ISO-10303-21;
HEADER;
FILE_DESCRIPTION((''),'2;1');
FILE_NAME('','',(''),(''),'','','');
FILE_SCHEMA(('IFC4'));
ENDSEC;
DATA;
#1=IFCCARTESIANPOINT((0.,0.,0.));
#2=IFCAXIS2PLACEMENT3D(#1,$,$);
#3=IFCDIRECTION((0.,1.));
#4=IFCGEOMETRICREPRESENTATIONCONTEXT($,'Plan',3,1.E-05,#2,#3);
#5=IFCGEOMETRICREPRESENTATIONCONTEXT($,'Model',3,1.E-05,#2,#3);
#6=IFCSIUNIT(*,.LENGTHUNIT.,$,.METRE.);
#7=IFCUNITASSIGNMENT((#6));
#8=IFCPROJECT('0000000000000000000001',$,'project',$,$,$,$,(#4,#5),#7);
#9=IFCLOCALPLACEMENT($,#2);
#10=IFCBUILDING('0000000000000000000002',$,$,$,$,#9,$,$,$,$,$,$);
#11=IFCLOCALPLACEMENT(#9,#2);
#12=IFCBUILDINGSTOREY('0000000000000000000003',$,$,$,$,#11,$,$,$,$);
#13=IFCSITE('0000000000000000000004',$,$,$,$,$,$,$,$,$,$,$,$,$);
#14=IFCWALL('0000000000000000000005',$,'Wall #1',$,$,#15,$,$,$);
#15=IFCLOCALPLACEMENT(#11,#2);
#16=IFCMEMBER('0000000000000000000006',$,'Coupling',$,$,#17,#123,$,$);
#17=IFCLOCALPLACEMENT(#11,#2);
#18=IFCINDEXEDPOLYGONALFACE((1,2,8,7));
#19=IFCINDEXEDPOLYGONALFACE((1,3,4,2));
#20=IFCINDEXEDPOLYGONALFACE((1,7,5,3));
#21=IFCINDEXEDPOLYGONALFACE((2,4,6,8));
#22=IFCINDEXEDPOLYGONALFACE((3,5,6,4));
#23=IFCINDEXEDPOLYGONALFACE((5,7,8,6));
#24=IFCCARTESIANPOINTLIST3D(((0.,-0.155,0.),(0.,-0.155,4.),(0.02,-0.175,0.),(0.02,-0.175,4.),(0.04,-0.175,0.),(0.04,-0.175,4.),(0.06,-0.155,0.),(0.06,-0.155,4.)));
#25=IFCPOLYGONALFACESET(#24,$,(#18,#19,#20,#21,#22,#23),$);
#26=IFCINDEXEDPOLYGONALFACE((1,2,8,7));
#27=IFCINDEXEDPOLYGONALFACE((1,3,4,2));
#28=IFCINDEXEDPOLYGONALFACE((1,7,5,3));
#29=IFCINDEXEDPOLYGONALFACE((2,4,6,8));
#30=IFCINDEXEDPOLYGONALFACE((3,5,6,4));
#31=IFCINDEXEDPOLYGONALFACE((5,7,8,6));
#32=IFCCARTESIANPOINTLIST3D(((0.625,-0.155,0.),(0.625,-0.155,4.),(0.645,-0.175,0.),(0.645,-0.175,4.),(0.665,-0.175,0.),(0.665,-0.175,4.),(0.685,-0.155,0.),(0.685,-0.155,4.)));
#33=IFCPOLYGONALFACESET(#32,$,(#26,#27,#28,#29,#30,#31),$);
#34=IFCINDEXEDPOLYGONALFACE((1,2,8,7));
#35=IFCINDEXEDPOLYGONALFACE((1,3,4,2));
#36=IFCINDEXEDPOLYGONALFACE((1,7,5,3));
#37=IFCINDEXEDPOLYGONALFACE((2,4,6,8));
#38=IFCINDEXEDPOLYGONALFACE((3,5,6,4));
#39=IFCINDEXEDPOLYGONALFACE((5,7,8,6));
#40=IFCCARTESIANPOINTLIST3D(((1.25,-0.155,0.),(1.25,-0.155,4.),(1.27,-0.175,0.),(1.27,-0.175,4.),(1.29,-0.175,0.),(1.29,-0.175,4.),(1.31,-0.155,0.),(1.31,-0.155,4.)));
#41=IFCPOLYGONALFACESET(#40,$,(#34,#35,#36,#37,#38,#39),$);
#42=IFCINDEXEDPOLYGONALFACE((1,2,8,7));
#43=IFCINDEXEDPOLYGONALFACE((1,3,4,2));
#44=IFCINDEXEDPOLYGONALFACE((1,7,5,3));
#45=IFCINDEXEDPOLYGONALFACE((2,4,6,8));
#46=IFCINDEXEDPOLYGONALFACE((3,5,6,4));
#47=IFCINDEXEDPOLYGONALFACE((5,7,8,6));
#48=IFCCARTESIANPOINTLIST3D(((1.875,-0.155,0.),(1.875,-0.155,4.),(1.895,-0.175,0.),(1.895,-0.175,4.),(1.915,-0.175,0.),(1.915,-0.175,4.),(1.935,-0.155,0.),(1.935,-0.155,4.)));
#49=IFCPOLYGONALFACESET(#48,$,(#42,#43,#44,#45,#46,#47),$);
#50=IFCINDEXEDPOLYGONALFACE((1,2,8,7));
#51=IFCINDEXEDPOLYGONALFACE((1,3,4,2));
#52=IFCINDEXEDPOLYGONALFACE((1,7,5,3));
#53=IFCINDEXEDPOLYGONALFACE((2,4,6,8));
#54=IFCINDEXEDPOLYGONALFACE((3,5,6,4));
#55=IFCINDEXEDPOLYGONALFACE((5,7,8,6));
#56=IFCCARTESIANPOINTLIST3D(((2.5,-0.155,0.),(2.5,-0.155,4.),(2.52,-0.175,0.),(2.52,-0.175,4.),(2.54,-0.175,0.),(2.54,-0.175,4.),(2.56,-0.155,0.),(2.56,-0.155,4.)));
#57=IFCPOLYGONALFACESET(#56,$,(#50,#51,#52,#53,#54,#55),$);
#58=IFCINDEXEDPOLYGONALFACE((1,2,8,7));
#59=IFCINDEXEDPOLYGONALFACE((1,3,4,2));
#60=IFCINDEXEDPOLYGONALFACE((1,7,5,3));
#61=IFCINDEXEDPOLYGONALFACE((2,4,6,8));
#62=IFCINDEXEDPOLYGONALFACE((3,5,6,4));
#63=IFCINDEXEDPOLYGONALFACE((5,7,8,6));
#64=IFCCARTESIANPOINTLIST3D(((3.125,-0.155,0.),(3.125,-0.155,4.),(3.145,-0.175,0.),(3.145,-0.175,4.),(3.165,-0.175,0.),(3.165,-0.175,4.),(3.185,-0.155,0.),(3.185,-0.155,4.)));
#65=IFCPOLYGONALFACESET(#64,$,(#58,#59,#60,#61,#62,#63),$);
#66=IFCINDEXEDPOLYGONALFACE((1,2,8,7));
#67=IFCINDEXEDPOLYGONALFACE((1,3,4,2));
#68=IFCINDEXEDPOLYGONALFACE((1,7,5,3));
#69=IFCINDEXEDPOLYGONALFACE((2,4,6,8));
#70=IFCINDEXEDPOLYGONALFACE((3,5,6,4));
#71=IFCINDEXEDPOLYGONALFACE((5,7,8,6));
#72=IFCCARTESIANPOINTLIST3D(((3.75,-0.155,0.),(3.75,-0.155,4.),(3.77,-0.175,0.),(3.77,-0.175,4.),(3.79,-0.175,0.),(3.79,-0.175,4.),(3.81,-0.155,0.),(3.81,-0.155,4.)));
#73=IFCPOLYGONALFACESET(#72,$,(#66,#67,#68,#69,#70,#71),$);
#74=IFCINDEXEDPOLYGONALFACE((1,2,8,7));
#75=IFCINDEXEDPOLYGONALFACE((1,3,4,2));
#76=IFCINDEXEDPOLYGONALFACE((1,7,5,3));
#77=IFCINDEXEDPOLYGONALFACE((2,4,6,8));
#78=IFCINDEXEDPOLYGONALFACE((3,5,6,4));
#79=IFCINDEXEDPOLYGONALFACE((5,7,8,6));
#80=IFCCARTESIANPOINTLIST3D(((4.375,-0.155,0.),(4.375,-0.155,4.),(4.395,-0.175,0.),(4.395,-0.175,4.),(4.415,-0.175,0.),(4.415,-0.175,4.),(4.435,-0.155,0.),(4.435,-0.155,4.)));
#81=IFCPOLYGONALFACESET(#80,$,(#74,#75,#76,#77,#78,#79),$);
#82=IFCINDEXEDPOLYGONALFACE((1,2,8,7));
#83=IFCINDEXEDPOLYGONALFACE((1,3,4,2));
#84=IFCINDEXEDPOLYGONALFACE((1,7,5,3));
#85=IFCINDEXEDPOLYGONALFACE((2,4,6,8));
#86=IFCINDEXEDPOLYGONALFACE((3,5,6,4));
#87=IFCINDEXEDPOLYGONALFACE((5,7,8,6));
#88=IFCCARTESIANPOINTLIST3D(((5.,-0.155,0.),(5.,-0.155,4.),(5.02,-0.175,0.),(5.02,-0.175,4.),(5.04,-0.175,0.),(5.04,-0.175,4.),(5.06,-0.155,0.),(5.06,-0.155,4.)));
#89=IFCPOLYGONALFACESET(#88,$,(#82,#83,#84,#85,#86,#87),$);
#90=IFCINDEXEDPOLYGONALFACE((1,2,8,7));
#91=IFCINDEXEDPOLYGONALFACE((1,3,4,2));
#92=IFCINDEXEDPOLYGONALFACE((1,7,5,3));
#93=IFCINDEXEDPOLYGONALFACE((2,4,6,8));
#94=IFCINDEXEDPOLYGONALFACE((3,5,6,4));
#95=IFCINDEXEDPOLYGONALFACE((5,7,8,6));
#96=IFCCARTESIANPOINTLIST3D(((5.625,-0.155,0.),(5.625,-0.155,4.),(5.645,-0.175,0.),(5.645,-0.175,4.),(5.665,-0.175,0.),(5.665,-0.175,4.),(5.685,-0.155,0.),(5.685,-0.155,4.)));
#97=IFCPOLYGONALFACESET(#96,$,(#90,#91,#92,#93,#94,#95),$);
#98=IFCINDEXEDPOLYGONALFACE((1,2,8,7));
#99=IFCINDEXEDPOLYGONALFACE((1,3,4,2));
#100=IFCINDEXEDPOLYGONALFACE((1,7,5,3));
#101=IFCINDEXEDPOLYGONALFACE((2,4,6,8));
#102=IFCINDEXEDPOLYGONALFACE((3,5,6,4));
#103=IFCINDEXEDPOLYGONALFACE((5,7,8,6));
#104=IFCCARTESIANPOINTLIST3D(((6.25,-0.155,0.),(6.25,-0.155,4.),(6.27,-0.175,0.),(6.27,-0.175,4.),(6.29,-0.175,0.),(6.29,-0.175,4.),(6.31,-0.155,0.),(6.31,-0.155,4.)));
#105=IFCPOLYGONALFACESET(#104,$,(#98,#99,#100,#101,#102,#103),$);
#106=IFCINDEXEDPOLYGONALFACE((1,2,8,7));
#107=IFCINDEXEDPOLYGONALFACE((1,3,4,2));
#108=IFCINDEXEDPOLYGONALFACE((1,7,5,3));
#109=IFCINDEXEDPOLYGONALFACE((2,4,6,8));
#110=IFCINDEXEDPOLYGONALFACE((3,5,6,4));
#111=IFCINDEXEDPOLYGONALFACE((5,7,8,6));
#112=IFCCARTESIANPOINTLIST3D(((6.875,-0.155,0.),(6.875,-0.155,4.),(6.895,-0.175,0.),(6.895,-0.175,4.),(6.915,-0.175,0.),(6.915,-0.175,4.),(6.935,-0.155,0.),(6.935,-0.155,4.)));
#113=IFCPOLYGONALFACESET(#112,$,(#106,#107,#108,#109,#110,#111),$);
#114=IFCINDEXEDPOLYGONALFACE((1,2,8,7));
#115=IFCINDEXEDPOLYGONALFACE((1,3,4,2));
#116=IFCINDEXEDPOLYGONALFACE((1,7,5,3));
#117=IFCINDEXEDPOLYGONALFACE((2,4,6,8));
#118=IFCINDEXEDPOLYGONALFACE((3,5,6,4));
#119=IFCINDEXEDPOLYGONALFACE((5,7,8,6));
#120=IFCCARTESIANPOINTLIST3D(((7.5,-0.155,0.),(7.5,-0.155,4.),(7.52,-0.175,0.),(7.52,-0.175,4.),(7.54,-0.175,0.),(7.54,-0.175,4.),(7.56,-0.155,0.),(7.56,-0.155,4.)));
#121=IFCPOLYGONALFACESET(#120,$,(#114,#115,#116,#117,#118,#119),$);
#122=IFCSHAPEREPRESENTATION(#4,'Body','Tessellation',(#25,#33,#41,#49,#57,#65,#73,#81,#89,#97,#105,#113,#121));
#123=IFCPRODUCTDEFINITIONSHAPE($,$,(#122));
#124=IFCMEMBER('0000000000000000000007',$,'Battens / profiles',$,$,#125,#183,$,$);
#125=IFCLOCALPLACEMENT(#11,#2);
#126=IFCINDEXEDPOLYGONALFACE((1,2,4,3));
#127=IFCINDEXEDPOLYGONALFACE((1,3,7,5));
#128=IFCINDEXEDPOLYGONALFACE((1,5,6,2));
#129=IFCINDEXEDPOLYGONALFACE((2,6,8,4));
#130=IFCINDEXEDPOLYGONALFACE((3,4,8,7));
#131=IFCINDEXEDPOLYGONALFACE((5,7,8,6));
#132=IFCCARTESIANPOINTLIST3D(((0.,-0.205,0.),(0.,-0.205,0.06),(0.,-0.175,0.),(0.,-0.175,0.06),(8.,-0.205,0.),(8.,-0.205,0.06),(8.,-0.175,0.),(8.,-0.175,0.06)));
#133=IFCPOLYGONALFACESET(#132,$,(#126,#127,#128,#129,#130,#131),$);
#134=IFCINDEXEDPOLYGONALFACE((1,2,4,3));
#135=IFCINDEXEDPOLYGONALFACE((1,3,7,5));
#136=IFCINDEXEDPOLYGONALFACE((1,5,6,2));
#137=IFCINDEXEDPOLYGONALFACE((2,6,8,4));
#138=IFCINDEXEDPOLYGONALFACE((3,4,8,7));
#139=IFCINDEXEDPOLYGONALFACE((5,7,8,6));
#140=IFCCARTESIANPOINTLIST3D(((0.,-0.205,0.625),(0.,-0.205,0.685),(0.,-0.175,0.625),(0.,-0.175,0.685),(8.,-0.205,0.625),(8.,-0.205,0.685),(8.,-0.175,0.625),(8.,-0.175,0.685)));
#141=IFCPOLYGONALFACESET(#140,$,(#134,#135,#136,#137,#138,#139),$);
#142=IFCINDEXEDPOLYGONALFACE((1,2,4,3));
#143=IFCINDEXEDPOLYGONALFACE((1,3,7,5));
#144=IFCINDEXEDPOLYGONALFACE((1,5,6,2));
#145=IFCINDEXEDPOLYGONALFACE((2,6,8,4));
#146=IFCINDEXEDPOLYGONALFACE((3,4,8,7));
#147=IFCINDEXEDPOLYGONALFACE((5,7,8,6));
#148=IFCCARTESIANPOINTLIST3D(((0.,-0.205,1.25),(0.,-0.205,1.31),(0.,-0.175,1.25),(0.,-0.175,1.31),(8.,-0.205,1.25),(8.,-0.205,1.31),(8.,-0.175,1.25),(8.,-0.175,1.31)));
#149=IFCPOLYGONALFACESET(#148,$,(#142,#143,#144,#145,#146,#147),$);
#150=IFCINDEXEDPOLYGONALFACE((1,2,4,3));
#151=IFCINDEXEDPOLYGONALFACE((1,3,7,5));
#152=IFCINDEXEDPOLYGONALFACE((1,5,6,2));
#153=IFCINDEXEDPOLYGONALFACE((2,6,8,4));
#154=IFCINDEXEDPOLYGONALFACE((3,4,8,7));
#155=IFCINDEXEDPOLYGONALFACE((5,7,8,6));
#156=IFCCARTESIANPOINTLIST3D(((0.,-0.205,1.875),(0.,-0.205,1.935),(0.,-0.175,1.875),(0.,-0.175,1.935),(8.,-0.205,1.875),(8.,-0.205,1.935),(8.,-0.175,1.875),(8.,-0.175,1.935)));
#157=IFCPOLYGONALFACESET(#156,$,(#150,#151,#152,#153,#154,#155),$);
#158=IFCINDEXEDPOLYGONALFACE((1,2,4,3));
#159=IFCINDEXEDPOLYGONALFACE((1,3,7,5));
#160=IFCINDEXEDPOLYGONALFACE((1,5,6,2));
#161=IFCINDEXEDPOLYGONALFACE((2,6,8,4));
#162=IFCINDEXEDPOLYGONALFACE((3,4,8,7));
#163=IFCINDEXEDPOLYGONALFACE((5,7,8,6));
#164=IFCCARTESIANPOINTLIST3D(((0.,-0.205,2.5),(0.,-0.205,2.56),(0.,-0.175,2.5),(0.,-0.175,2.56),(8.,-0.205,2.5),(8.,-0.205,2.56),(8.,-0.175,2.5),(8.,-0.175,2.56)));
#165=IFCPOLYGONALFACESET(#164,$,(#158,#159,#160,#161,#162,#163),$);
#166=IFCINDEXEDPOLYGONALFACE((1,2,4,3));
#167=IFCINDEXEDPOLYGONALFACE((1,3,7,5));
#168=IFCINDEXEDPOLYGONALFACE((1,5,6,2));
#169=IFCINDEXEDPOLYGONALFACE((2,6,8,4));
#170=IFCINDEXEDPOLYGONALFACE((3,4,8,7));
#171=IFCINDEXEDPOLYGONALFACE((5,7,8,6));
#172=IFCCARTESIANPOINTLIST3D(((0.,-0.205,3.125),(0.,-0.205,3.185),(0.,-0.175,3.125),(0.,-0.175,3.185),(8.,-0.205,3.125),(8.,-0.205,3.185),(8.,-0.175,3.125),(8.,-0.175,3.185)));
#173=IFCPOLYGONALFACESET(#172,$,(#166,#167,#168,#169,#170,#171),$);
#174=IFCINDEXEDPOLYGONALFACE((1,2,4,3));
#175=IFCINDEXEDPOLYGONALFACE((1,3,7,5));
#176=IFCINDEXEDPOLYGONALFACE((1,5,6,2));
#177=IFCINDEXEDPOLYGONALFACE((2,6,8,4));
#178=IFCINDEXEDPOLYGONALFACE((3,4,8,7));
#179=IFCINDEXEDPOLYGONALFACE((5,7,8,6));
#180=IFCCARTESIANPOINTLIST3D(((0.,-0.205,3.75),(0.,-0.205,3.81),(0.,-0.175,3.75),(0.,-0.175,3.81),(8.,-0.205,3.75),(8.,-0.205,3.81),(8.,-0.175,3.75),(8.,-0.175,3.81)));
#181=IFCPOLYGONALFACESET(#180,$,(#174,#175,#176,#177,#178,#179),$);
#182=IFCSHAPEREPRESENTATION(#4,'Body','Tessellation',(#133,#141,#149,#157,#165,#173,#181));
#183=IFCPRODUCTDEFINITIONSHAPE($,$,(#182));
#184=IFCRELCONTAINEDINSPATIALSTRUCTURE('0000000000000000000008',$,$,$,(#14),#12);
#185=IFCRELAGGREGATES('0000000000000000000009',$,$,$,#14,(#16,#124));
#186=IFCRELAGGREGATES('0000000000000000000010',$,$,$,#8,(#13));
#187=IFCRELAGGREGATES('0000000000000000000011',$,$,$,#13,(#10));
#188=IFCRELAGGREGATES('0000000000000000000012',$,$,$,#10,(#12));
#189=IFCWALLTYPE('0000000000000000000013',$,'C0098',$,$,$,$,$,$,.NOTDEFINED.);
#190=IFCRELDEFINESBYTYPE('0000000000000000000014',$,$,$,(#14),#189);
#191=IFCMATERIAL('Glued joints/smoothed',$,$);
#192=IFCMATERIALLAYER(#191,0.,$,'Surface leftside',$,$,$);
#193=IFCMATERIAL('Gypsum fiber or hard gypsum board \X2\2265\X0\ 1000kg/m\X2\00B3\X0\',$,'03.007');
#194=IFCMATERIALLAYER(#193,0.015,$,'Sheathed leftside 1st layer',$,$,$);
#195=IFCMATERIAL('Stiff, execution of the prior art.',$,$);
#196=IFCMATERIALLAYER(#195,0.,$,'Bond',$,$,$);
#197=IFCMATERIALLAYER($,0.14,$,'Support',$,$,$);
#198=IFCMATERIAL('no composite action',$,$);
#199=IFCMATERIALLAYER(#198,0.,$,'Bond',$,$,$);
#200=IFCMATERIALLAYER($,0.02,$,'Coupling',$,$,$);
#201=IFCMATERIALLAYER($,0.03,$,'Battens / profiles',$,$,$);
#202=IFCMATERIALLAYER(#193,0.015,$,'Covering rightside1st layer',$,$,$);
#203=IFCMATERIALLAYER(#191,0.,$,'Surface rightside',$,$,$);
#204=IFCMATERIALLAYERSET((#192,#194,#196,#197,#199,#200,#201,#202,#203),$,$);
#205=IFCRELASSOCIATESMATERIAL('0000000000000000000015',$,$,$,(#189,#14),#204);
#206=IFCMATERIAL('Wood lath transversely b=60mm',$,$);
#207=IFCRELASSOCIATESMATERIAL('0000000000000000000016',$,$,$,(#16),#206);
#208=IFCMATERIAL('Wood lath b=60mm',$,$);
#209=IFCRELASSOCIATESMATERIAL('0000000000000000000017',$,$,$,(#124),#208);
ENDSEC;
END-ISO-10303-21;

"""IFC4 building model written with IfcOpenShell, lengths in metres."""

from ifc_helpers import new_model, si_unit, direction, frame, frame_2d, origin, place, context, project, spatial, polyline, rectangle, outline, extrude, material, layer, layer_set, type_object, element, aggregate, save


model = new_model("IFC4")

# Units and contexts
plan_context = context("Plan", 3, precision=1e-05, world=origin(), true_north=direction((0.0, 1.0)))
model_context = context("Model", 3, precision=1e-05, world=origin(), true_north=direction((0.0, 1.0)))
ifc_project = project(units=[si_unit("LENGTHUNIT", "METRE")], contexts=[plan_context, model_context])

# Site, building, storey
site = spatial("IfcSite", under=ifc_project)
building_placement = place(None, origin())
building = spatial("IfcBuilding", under=site, at=building_placement)
storey_placement = place(building_placement, origin())
storey = spatial("IfcBuildingStorey", under=building, at=storey_placement)

# Wall, members
ifc_material_1 = material(Name="Glued joints/smoothed")
ifc_layer_1 = layer(ifc_material_1, 0.0, Name="Surface leftside")
ifc_material_2 = material(Name="Gypsum fiber or hard gypsum board ≥ 1000kg/m³", Category="03.007")
ifc_layer_2 = layer(ifc_material_2, 0.015, Name="Sheathed leftside 1st layer")
ifc_material_3 = material(Name="Stiff, execution of the prior art.")
ifc_layer_3 = layer(ifc_material_3, 0.0, Name="Bond")
ifc_layer_4 = layer(None, 0.14, Name="Support")
ifc_material_4 = material(Name="no composite action")
ifc_layer_5 = layer(ifc_material_4, 0.0, Name="Bond")
ifc_layer_6 = layer(None, 0.02, Name="Coupling")
ifc_layer_7 = layer(None, 0.03, Name="Battens / profiles")
ifc_layer_8 = layer(ifc_material_2, 0.015, Name="Covering rightside1st layer")
ifc_layer_9 = layer(ifc_material_1, 0.0, Name="Surface rightside")
ifc_layer_set = layer_set([ifc_layer_1, ifc_layer_2, ifc_layer_3, ifc_layer_4, ifc_layer_5, ifc_layer_6, ifc_layer_7, ifc_layer_8, ifc_layer_9])
wall_type = type_object("IfcWallType", Name="C0098", PredefinedType="NOTDEFINED", material=ifc_layer_set)
wall_placement = place(None, frame((0.0, 0.0, 0.0), z_axis=(0.0, -1.0, 0.0), x_axis=(1.0, 0.0, 0.0)))
wall = element("IfcWall", 1, at=wall_placement, inside=storey, type_object=wall_type, material=ifc_layer_set, Name="Wall #1")
ifc_material_5 = material(Name="Wood lath transversely b=60mm")
member_1_placement = place(wall_placement, origin())
member_1 = element("IfcMember", 2, at=member_1_placement, material=ifc_material_5, Name="Coupling", context=plan_context, shape_type="SweptSolid", body=[
    extrude(outline(polyline([(0.0, 0.0), (0.06, 0.0), (0.04, 0.02), (0.02, 0.02), (0.0, 0.0)])), frame((0.0, 4.0, 0.155), z_axis=(0.0, -1.0, 0.0), x_axis=(1.0, 0.0, 0.0)), (0.0, 0.0, 1.0), 4.0),
    extrude(outline(polyline([(0.0, 0.0), (0.06, 0.0), (0.04, 0.02), (0.02, 0.02), (0.0, 0.0)])), frame((0.625, 4.0, 0.155), z_axis=(0.0, -1.0, 0.0), x_axis=(1.0, 0.0, 0.0)), (0.0, 0.0, 1.0), 4.0),
    extrude(outline(polyline([(0.0, 0.0), (0.06, 0.0), (0.04, 0.02), (0.02, 0.02), (0.0, 0.0)])), frame((1.25, 4.0, 0.155), z_axis=(0.0, -1.0, 0.0), x_axis=(1.0, 0.0, 0.0)), (0.0, 0.0, 1.0), 4.0),
    extrude(outline(polyline([(0.0, 0.0), (0.06, 0.0), (0.04, 0.02), (0.02, 0.02), (0.0, 0.0)])), frame((1.875, 4.0, 0.155), z_axis=(0.0, -1.0, 0.0), x_axis=(1.0, 0.0, 0.0)), (0.0, 0.0, 1.0), 4.0),
    extrude(outline(polyline([(0.0, 0.0), (0.06, 0.0), (0.04, 0.02), (0.02, 0.02), (0.0, 0.0)])), frame((2.5, 4.0, 0.155), z_axis=(0.0, -1.0, 0.0), x_axis=(1.0, 0.0, 0.0)), (0.0, 0.0, 1.0), 4.0),
    extrude(outline(polyline([(0.0, 0.0), (0.06, 0.0), (0.04, 0.02), (0.02, 0.02), (0.0, 0.0)])), frame((3.125, 4.0, 0.155), z_axis=(0.0, -1.0, 0.0), x_axis=(1.0, 0.0, 0.0)), (0.0, 0.0, 1.0), 4.0),
    extrude(outline(polyline([(0.0, 0.0), (0.06, 0.0), (0.04, 0.02), (0.02, 0.02), (0.0, 0.0)])), frame((3.75, 4.0, 0.155), z_axis=(0.0, -1.0, 0.0), x_axis=(1.0, 0.0, 0.0)), (0.0, 0.0, 1.0), 4.0),
    extrude(outline(polyline([(0.0, 0.0), (0.06, 0.0), (0.04, 0.02), (0.02, 0.02), (0.0, 0.0)])), frame((4.375, 4.0, 0.155), z_axis=(0.0, -1.0, 0.0), x_axis=(1.0, 0.0, 0.0)), (0.0, 0.0, 1.0), 4.0),
    extrude(outline(polyline([(0.0, 0.0), (0.06, 0.0), (0.04, 0.02), (0.02, 0.02), (0.0, 0.0)])), frame((5.0, 4.0, 0.155), z_axis=(0.0, -1.0, 0.0), x_axis=(1.0, 0.0, 0.0)), (0.0, 0.0, 1.0), 4.0),
    extrude(outline(polyline([(0.0, 0.0), (0.06, 0.0), (0.04, 0.02), (0.02, 0.02), (0.0, 0.0)])), frame((5.625, 4.0, 0.155), z_axis=(0.0, -1.0, 0.0), x_axis=(1.0, 0.0, 0.0)), (0.0, 0.0, 1.0), 4.0),
    extrude(outline(polyline([(0.0, 0.0), (0.06, 0.0), (0.04, 0.02), (0.02, 0.02), (0.0, 0.0)])), frame((6.25, 4.0, 0.155), z_axis=(0.0, -1.0, 0.0), x_axis=(1.0, 0.0, 0.0)), (0.0, 0.0, 1.0), 4.0),
    extrude(outline(polyline([(0.0, 0.0), (0.06, 0.0), (0.04, 0.02), (0.02, 0.02), (0.0, 0.0)])), frame((6.875, 4.0, 0.155), z_axis=(0.0, -1.0, 0.0), x_axis=(1.0, 0.0, 0.0)), (0.0, 0.0, 1.0), 4.0),
    extrude(outline(polyline([(0.0, 0.0), (0.06, 0.0), (0.04, 0.02), (0.02, 0.02), (0.0, 0.0)])), frame((7.5, 4.0, 0.155), z_axis=(0.0, -1.0, 0.0), x_axis=(1.0, 0.0, 0.0)), (0.0, 0.0, 1.0), 4.0),
])
ifc_material_6 = material(Name="Wood lath b=60mm")
member_2_placement = place(wall_placement, origin())
member_2 = element("IfcMember", 3, at=member_2_placement, material=ifc_material_6, Name="Battens / profiles", context=plan_context, shape_type="SweptSolid", body=[
    extrude(rectangle(XDim=0.06, YDim=0.03, at=frame_2d((0.03, 0.015), x_axis=(1.0, 0.0))), frame((0.0, 0.0, 0.175), z_axis=(1.0, 0.0, 0.0), x_axis=(0.0, 1.0, 0.0)), (0.0, 0.0, 1.0), 8.0),
    extrude(rectangle(XDim=0.06, YDim=0.03, at=frame_2d((0.03, 0.015), x_axis=(1.0, 0.0))), frame((0.0, 0.625, 0.175), z_axis=(1.0, 0.0, 0.0), x_axis=(0.0, 1.0, 0.0)), (0.0, 0.0, 1.0), 8.0),
    extrude(rectangle(XDim=0.06, YDim=0.03, at=frame_2d((0.03, 0.015), x_axis=(1.0, 0.0))), frame((0.0, 1.25, 0.175), z_axis=(1.0, 0.0, 0.0), x_axis=(0.0, 1.0, 0.0)), (0.0, 0.0, 1.0), 8.0),
    extrude(rectangle(XDim=0.06, YDim=0.03, at=frame_2d((0.03, 0.015), x_axis=(1.0, 0.0))), frame((0.0, 1.875, 0.175), z_axis=(1.0, 0.0, 0.0), x_axis=(0.0, 1.0, 0.0)), (0.0, 0.0, 1.0), 8.0),
    extrude(rectangle(XDim=0.06, YDim=0.03, at=frame_2d((0.03, 0.015), x_axis=(1.0, 0.0))), frame((0.0, 2.5, 0.175), z_axis=(1.0, 0.0, 0.0), x_axis=(0.0, 1.0, 0.0)), (0.0, 0.0, 1.0), 8.0),
    extrude(rectangle(XDim=0.06, YDim=0.03, at=frame_2d((0.03, 0.015), x_axis=(1.0, 0.0))), frame((0.0, 3.125, 0.175), z_axis=(1.0, 0.0, 0.0), x_axis=(0.0, 1.0, 0.0)), (0.0, 0.0, 1.0), 8.0),
    extrude(rectangle(XDim=0.06, YDim=0.03, at=frame_2d((0.03, 0.015), x_axis=(1.0, 0.0))), frame((0.0, 3.75, 0.175), z_axis=(1.0, 0.0, 0.0), x_axis=(0.0, 1.0, 0.0)), (0.0, 0.0, 1.0), 8.0),
])
aggregate(wall, [member_1, member_2])

save(model, "model.ifc")
